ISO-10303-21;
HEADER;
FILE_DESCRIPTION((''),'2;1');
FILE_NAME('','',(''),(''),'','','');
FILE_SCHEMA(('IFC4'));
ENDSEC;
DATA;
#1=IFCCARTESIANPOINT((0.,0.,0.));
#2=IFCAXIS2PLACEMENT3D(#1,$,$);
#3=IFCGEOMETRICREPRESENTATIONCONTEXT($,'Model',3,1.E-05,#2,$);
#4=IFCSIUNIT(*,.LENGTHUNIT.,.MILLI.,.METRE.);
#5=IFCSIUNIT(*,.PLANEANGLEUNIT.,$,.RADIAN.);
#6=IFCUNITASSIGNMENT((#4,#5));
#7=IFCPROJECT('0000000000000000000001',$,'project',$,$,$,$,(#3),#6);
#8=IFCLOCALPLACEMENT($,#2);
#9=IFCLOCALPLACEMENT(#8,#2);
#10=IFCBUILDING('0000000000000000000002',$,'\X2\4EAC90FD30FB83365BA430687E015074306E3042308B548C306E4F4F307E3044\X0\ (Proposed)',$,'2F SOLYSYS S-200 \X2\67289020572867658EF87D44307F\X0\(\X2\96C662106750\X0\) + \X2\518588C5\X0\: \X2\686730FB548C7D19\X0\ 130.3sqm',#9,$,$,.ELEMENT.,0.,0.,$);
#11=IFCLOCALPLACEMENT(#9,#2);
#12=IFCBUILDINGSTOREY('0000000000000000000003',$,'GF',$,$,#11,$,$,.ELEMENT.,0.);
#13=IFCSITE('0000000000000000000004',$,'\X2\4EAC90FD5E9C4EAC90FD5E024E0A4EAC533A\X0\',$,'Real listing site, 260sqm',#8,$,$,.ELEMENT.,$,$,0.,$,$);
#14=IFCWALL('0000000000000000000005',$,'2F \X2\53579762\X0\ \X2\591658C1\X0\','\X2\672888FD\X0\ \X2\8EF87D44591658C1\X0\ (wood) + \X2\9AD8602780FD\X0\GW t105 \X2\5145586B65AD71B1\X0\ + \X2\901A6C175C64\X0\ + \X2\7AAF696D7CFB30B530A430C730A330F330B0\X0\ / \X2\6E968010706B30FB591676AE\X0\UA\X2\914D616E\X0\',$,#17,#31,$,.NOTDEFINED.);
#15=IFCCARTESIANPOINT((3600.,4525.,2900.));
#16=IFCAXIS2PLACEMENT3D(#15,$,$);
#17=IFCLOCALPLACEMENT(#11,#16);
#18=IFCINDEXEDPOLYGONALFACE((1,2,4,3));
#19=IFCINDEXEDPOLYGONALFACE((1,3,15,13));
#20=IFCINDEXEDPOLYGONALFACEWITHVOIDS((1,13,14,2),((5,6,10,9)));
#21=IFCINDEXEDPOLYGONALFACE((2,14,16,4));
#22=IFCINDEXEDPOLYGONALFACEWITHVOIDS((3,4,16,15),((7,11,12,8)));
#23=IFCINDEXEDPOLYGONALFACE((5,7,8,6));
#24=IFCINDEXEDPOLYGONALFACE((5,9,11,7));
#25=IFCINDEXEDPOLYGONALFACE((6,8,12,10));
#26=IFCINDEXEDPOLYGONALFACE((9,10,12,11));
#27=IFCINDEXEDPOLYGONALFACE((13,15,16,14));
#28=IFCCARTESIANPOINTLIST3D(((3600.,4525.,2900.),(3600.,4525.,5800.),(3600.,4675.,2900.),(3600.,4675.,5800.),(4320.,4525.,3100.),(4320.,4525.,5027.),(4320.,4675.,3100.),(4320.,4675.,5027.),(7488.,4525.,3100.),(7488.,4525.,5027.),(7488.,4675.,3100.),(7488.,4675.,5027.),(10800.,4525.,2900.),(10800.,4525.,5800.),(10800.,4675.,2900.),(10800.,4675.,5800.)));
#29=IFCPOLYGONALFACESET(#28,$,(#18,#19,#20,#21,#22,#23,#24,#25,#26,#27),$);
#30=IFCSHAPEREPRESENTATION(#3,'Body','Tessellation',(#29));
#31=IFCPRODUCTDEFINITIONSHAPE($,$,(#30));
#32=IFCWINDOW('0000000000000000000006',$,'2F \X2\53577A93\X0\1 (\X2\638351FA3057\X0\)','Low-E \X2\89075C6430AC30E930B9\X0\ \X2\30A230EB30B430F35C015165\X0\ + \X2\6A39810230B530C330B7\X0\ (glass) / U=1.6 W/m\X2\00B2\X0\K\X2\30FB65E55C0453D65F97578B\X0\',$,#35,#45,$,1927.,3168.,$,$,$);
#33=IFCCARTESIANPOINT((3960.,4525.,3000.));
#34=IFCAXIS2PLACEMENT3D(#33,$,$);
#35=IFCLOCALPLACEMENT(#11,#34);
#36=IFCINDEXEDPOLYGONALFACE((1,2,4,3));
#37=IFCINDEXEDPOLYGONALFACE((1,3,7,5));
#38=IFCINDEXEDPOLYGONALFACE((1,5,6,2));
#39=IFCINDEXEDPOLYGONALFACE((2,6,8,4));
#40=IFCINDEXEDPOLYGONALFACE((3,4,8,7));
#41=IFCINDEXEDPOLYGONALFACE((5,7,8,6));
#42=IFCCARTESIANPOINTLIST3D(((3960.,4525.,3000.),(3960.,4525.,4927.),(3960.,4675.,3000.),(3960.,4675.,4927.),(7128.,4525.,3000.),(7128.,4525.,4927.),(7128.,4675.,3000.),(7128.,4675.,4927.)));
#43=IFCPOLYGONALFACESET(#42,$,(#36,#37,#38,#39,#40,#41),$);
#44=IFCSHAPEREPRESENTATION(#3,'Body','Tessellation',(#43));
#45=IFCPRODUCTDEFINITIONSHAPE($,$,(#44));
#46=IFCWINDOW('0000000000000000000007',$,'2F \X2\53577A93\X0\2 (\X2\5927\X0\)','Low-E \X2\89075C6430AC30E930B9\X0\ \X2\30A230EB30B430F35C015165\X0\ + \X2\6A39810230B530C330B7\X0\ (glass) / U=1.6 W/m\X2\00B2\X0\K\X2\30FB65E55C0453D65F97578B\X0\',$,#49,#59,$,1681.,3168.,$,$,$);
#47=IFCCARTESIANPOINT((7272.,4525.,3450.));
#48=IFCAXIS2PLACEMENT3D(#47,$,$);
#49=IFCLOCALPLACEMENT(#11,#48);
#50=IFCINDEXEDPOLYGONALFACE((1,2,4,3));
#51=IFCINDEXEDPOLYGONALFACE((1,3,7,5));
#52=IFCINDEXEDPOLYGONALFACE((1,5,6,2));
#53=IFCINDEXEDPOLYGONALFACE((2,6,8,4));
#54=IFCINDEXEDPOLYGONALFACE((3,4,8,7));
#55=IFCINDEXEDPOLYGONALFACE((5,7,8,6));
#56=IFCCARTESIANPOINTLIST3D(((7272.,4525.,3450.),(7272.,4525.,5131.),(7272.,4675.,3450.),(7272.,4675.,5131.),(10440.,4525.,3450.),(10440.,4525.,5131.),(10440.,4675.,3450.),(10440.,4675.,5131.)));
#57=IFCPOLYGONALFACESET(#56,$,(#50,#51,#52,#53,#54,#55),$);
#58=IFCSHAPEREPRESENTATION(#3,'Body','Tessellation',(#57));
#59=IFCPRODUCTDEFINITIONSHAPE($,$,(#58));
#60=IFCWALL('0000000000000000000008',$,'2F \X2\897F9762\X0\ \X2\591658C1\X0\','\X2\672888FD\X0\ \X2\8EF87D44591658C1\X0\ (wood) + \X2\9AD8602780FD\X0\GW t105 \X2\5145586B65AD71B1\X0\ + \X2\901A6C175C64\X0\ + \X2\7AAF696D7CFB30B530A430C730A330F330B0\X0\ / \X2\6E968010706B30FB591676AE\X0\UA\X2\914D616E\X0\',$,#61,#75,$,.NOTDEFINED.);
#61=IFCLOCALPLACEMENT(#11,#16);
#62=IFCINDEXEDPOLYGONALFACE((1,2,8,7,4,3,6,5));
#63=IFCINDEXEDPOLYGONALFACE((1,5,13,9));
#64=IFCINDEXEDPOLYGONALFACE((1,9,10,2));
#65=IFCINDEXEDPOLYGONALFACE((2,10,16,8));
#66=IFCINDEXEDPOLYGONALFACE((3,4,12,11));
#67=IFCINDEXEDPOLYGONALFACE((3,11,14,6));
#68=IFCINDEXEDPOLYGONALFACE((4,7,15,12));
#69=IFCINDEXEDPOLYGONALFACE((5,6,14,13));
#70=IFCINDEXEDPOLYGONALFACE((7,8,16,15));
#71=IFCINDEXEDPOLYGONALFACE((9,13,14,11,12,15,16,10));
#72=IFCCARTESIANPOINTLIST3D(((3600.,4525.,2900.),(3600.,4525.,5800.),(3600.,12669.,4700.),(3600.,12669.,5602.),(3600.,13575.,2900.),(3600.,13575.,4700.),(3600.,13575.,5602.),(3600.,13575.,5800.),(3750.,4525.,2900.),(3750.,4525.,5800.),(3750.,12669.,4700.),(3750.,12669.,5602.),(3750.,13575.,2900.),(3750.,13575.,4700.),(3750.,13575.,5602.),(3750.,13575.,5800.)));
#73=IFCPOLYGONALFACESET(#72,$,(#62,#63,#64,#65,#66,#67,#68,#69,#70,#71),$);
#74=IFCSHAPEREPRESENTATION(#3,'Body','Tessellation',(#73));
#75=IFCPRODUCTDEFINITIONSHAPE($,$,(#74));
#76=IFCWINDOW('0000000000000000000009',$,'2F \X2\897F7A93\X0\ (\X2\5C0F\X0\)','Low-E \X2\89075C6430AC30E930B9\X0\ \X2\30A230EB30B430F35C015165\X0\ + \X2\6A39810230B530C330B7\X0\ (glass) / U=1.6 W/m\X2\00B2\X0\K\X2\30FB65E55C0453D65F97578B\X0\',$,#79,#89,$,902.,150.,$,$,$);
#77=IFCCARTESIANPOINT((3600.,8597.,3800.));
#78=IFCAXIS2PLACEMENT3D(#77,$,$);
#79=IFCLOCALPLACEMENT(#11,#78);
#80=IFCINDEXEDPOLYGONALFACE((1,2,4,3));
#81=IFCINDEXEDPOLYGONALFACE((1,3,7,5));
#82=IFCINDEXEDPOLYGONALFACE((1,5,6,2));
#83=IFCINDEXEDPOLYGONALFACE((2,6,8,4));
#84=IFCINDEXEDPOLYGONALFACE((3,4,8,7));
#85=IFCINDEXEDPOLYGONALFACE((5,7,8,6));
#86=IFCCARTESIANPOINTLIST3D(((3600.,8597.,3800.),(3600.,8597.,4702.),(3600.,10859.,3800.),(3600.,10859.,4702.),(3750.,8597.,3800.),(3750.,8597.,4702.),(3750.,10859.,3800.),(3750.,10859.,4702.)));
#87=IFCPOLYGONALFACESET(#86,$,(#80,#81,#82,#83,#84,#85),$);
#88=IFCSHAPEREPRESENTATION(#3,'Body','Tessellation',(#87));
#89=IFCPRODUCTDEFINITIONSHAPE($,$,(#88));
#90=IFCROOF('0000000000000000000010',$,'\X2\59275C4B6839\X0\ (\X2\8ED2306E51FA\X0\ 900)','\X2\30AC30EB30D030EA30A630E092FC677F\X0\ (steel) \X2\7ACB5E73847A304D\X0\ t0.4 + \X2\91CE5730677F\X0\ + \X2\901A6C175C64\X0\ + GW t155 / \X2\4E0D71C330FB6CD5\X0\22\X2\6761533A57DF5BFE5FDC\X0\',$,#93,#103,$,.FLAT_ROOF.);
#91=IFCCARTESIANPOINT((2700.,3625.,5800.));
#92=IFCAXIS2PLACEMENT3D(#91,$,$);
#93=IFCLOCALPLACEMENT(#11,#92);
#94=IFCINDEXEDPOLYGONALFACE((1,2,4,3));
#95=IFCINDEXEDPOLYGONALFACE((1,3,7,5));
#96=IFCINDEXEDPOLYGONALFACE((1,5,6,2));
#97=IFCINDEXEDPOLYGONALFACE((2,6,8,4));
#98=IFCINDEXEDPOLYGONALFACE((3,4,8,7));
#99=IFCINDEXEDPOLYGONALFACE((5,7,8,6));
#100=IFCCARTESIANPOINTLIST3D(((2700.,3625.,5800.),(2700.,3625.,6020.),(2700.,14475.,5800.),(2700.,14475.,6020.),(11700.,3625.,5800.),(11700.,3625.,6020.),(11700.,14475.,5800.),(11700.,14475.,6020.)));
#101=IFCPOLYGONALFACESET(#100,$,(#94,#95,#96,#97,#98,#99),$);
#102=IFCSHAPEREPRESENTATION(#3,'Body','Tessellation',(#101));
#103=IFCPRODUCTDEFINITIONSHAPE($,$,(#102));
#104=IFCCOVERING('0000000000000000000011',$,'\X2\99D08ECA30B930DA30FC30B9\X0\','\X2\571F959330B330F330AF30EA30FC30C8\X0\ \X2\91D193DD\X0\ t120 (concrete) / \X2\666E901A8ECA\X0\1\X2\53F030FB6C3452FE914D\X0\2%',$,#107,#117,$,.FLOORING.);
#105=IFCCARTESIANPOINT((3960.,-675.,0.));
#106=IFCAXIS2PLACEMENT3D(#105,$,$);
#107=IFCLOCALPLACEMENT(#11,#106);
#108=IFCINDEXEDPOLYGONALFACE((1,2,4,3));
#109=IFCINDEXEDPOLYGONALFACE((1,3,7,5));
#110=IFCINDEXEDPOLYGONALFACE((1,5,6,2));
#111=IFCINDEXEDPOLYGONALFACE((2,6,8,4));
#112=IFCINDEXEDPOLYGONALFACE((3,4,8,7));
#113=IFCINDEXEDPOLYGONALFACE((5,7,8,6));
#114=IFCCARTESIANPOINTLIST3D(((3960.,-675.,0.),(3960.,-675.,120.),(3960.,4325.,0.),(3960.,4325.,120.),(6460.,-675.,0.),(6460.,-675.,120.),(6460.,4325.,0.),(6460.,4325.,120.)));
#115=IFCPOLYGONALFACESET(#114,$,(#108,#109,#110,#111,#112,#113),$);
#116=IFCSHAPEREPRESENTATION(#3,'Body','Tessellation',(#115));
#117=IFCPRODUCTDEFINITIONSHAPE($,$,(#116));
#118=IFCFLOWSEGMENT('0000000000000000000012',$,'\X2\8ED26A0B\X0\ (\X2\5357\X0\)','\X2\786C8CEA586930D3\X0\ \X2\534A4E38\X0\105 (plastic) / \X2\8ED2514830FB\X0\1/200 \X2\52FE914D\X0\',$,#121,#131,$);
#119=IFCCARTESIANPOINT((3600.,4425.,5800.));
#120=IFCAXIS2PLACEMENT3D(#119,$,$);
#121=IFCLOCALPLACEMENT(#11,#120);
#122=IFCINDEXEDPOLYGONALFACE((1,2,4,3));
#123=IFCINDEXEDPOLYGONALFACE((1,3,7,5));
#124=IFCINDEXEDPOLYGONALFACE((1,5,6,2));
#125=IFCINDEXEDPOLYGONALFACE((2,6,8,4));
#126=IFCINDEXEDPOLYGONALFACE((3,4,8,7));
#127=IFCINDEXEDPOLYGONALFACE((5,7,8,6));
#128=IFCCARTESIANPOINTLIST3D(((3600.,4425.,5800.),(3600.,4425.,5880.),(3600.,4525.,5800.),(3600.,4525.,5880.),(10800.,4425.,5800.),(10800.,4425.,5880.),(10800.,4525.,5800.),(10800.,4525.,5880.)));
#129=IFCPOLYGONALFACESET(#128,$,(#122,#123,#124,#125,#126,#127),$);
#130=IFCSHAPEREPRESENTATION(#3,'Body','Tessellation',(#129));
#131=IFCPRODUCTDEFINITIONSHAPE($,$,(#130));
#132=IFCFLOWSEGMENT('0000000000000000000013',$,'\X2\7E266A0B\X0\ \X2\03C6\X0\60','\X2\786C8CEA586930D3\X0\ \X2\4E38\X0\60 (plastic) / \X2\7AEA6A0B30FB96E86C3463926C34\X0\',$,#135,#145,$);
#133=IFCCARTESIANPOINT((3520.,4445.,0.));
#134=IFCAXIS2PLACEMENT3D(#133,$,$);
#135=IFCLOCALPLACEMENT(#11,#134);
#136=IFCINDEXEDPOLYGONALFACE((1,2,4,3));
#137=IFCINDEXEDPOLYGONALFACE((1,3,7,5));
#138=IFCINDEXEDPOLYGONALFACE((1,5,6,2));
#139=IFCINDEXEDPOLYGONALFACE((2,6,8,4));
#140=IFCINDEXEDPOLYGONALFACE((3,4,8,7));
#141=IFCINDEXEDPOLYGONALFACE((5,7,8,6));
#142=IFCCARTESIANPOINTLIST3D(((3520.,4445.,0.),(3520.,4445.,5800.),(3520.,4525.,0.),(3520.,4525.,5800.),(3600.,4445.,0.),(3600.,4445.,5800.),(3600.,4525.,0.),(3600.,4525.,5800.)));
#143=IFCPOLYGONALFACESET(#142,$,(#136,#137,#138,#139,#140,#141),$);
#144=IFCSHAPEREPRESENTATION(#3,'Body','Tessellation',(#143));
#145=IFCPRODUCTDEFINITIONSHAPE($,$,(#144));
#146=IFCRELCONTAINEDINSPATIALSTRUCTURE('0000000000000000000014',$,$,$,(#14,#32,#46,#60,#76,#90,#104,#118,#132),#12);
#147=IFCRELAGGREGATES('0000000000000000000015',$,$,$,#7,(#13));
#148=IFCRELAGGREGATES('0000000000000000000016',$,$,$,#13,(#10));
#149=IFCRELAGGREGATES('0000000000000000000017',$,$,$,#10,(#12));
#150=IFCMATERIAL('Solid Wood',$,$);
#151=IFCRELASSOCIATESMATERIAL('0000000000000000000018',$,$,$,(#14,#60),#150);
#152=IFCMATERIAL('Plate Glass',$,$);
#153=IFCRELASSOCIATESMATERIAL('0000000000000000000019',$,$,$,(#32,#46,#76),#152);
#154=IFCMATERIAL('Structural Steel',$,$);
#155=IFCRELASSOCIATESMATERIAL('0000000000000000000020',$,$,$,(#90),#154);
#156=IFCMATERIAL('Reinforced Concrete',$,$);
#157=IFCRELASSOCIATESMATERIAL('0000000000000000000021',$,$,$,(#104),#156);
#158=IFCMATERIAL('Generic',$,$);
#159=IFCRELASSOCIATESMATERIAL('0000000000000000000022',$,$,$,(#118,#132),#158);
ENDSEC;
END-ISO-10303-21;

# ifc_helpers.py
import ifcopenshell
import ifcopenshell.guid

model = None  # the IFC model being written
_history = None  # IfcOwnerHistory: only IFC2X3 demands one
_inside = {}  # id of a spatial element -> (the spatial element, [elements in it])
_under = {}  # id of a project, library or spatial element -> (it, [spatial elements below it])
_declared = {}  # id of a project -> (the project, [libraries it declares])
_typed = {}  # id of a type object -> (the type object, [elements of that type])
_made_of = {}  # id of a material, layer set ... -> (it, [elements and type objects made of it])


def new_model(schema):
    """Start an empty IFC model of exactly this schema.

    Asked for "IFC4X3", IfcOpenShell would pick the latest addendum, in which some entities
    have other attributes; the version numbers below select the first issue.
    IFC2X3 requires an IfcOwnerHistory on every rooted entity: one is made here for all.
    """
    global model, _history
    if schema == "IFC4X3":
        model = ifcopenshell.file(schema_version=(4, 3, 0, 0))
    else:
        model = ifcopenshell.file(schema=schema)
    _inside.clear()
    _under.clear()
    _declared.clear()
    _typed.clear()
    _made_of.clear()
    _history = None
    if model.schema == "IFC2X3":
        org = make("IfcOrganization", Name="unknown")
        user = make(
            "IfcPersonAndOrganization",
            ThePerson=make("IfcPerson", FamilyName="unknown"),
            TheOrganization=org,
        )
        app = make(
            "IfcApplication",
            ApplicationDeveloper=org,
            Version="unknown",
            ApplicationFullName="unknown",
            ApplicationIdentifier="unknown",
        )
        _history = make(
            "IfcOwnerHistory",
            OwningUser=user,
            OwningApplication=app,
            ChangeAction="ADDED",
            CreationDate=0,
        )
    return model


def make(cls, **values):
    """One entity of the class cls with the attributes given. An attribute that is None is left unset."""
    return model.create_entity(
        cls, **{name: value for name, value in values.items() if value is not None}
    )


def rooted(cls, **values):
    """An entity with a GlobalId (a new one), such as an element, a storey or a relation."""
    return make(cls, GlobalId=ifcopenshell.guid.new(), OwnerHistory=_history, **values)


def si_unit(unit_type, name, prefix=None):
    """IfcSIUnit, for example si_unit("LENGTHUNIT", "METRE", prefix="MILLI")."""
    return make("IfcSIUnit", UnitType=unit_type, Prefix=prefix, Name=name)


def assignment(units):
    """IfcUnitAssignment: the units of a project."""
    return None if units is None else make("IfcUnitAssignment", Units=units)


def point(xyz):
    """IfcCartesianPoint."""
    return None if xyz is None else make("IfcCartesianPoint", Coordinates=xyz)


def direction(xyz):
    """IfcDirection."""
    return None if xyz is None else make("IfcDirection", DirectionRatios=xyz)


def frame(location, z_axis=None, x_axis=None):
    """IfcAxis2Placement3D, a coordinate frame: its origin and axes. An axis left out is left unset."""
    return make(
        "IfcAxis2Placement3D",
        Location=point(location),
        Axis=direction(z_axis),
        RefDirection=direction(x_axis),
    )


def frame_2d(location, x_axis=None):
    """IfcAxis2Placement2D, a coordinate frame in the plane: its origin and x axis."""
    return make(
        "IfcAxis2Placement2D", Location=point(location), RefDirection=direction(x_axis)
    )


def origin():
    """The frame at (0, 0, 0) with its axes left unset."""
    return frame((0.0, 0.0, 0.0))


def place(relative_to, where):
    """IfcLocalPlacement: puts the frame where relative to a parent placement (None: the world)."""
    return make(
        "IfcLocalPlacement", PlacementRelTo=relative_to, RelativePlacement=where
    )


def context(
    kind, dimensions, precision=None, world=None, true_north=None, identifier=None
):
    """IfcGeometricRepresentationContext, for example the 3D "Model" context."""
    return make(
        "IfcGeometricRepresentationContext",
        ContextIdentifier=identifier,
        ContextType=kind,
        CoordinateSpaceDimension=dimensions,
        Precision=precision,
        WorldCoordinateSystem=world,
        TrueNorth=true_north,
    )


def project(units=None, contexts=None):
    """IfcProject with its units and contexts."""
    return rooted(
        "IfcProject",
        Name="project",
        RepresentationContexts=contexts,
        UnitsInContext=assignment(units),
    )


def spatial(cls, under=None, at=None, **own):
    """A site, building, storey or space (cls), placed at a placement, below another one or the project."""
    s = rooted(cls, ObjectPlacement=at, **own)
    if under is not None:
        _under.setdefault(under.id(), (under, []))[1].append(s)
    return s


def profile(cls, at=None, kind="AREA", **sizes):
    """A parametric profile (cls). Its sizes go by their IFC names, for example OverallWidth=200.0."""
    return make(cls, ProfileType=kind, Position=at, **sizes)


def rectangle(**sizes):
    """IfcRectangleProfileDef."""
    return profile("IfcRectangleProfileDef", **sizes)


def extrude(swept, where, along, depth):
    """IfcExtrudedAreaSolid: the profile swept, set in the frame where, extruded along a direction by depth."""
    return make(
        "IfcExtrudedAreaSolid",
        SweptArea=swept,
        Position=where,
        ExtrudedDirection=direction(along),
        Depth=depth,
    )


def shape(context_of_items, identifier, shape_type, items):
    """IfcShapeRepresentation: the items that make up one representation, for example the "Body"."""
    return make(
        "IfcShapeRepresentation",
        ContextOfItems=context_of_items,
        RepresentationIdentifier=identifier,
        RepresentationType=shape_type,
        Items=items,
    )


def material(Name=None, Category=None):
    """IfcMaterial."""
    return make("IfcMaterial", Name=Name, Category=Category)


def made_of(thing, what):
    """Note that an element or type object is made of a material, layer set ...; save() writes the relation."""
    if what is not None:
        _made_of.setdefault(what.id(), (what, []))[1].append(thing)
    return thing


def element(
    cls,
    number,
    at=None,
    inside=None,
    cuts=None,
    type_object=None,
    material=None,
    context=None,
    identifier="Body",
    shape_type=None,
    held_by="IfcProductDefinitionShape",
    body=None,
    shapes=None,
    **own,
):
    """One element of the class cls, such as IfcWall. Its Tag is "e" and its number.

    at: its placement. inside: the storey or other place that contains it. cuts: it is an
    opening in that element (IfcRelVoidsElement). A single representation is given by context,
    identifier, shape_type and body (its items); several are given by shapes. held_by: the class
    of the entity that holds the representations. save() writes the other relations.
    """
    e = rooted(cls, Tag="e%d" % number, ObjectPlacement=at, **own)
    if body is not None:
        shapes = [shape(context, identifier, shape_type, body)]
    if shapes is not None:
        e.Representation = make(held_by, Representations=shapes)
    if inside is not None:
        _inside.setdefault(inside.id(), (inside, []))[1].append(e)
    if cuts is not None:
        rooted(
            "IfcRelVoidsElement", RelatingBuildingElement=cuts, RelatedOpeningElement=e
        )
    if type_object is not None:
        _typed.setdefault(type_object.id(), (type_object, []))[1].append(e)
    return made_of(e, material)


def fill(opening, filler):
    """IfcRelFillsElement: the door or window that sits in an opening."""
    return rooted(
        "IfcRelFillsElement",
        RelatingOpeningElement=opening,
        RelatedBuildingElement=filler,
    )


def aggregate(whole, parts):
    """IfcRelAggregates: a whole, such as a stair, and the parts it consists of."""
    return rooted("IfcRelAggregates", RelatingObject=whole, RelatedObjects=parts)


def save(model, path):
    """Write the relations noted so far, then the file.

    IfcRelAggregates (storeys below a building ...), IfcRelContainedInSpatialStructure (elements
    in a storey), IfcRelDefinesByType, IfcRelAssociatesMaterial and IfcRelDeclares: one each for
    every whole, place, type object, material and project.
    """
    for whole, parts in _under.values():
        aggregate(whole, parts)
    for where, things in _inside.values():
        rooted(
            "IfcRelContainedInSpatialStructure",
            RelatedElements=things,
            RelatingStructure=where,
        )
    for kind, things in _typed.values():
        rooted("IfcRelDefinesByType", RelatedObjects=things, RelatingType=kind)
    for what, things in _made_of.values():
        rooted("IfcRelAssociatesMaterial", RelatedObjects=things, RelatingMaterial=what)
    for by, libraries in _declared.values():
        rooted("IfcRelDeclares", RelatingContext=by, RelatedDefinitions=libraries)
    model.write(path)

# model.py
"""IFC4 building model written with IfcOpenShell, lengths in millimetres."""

from ifc_helpers import new_model, si_unit, frame, frame_2d, origin, place, context, project, spatial, rectangle, extrude, material, element, fill, save


model = new_model("IFC4")

# Units and contexts
model_context = context("Model", 3, precision=1e-05, world=origin())
ifc_project = project(units=[si_unit("LENGTHUNIT", "METRE", prefix="MILLI"), si_unit("PLANEANGLEUNIT", "RADIAN")], contexts=[model_context])

# Site, building, storey
site_placement = place(None, origin())
site = spatial("IfcSite", under=ifc_project, at=site_placement, Name="京都府京都市上京区", ObjectType="Real listing site, 260sqm", CompositionType="ELEMENT", RefElevation=0.0)
building_placement = place(site_placement, origin())
building = spatial("IfcBuilding", under=site, at=building_placement, Name="京都・茶室と縁側のある和の住まい (Proposed)", ObjectType="2F SOLYSYS S-200 木造在来軸組み(集成材) + 内装: 桧・和紙 130.3sqm", CompositionType="ELEMENT", ElevationOfRefHeight=0.0, ElevationOfTerrain=0.0)
storey_placement = place(building_placement, origin())
storey = spatial("IfcBuildingStorey", under=building, at=storey_placement, Name="GF", CompositionType="ELEMENT", Elevation=0.0)

# Shared definitions
ifc_material_1 = material(Name="Solid Wood")

# Shared definitions
ifc_material_2 = material(Name="Reinforced Concrete")

# Shared definitions
ifc_material_3 = material(Name="Plate Glass")

# Wall, openings, windows
wall_1_placement = place(storey_placement, frame((3600.0, 4525.0, 2900.0)))
wall_1 = element("IfcWall", 1, at=wall_1_placement, inside=storey, material=ifc_material_1, Name="2F 南面 外壁", Description="木製 軸組外壁 (wood) + 高性能GW t105 充填断熱 + 通気層 + 窯業系サイディング / 準耐火・外皮UA配慮", PredefinedType="NOTDEFINED", context=model_context, shape_type="SweptSolid", body=[
    extrude(rectangle(XDim=7200.0, YDim=150.0, at=frame_2d((3600.0, 75.0))), frame((3600.0, 4525.0, 2900.0)), (0.0, 0.0, 1.0), 2900.0),
])
opening_1_placement = place(storey_placement, frame((3960.0, 4525.0, 3000.0)))
opening_1 = element("IfcOpeningElement", 2, at=opening_1_placement, cuts=wall_1, PredefinedType="NOTDEFINED", context=model_context, shape_type="SweptSolid", body=[
    extrude(rectangle(XDim=3168.0, YDim=150.0, at=frame_2d((1584.0, 75.0))), frame((3960.0, 4525.0, 3000.0)), (0.0, 0.0, 1.0), 1927.0),
])
opening_2_placement = place(storey_placement, frame((7272.0, 4525.0, 3450.0)))
opening_2 = element("IfcOpeningElement", 3, at=opening_2_placement, cuts=wall_1, PredefinedType="NOTDEFINED", context=model_context, shape_type="SweptSolid", body=[
    extrude(rectangle(XDim=3168.0, YDim=150.0, at=frame_2d((1584.0, 75.0))), frame((7272.0, 4525.0, 3450.0)), (0.0, 0.0, 1.0), 1681.0),
])
window_1_placement = place(storey_placement, frame((3960.0, 4525.0, 3000.0)))
window_1 = element("IfcWindow", 4, at=window_1_placement, inside=storey, material=ifc_material_3, Name="2F 南窓1 (掃出し)", Description="Low-E 複層ガラス アルゴン封入 + 樹脂サッシ (glass) / U=1.6 W/m²K・日射取得型", OverallHeight=1927.0, OverallWidth=3168.0, context=model_context, shape_type="SweptSolid", body=[
    extrude(rectangle(XDim=3168.0, YDim=150.0, at=frame_2d((1584.0, 75.0))), frame((3960.0, 4525.0, 3000.0)), (0.0, 0.0, 1.0), 1927.0),
])
fill(opening_1, window_1)
window_2_placement = place(storey_placement, frame((7272.0, 4525.0, 3450.0)))
window_2 = element("IfcWindow", 5, at=window_2_placement, inside=storey, material=ifc_material_3, Name="2F 南窓2 (大)", Description="Low-E 複層ガラス アルゴン封入 + 樹脂サッシ (glass) / U=1.6 W/m²K・日射取得型", OverallHeight=1681.0, OverallWidth=3168.0, context=model_context, shape_type="SweptSolid", body=[
    extrude(rectangle(XDim=3168.0, YDim=150.0, at=frame_2d((1584.0, 75.0))), frame((7272.0, 4525.0, 3450.0)), (0.0, 0.0, 1.0), 1681.0),
])
fill(opening_2, window_2)

# Wall, opening, window
wall_2_placement = place(storey_placement, frame((3600.0, 4525.0, 2900.0)))
wall_2 = element("IfcWall", 6, at=wall_2_placement, inside=storey, material=ifc_material_1, Name="2F 西面 外壁", Description="木製 軸組外壁 (wood) + 高性能GW t105 充填断熱 + 通気層 + 窯業系サイディング / 準耐火・外皮UA配慮", PredefinedType="NOTDEFINED", context=model_context, shape_type="SweptSolid", body=[
    extrude(rectangle(XDim=150.0, YDim=9050.0, at=frame_2d((75.0, 4525.0))), frame((3600.0, 4525.0, 2900.0)), (0.0, 0.0, 1.0), 2900.0),
])
opening_3_placement = place(storey_placement, frame((3600.0, 8597.0, 3800.0)))
opening_3 = element("IfcOpeningElement", 7, at=opening_3_placement, cuts=wall_2, PredefinedType="NOTDEFINED", context=model_context, shape_type="SweptSolid", body=[
    extrude(rectangle(XDim=150.0, YDim=2262.0, at=frame_2d((75.0, 1131.0))), frame((3600.0, 8597.0, 3800.0)), (0.0, 0.0, 1.0), 902.0),
])
window_3_placement = place(storey_placement, frame((3600.0, 8597.0, 3800.0)))
window_3 = element("IfcWindow", 8, at=window_3_placement, inside=storey, material=ifc_material_3, Name="2F 西窓 (小)", Description="Low-E 複層ガラス アルゴン封入 + 樹脂サッシ (glass) / U=1.6 W/m²K・日射取得型", OverallHeight=902.0, OverallWidth=150.0, context=model_context, shape_type="SweptSolid", body=[
    extrude(rectangle(XDim=150.0, YDim=2262.0, at=frame_2d((75.0, 1131.0))), frame((3600.0, 8597.0, 3800.0)), (0.0, 0.0, 1.0), 902.0),
])
fill(opening_3, window_3)

# Roof
ifc_material_4 = material(Name="Structural Steel")
roof_placement = place(storey_placement, frame((2700.0, 3625.0, 5800.0)))
element("IfcRoof", 9, at=roof_placement, inside=storey, material=ifc_material_4, Name="大屋根 (軒の出 900)", Description="ガルバリウム鋼板 (steel) 立平葺き t0.4 + 野地板 + 通気層 + GW t155 / 不燃・法22条区域対応", PredefinedType="FLAT_ROOF", context=model_context, shape_type="SweptSolid", body=[
    extrude(rectangle(XDim=9000.0, YDim=10850.0, at=frame_2d((4500.0, 5425.0))), frame((2700.0, 3625.0, 5800.0)), (0.0, 0.0, 1.0), 220.0),
])

# Covering
covering_placement = place(storey_placement, frame((3960.0, -675.0, 0.0)))
element("IfcCovering", 10, at=covering_placement, inside=storey, material=ifc_material_2, Name="駐車スペース", Description="土間コンクリート 金鏝 t120 (concrete) / 普通車1台・水勾配2%", PredefinedType="FLOORING", context=model_context, shape_type="SweptSolid", body=[
    extrude(rectangle(XDim=2500.0, YDim=5000.0, at=frame_2d((1250.0, 2500.0))), frame((3960.0, -675.0, 0.0)), (0.0, 0.0, 1.0), 120.0),
])

# Flow segments
ifc_material_5 = material(Name="Generic")
flow_segment_1_placement = place(storey_placement, frame((3600.0, 4425.0, 5800.0)))
element("IfcFlowSegment", 11, at=flow_segment_1_placement, inside=storey, material=ifc_material_5, Name="軒樋 (南)", Description="硬質塩ビ 半丸105 (plastic) / 軒先・1/200 勾配", context=model_context, shape_type="SweptSolid", body=[
    extrude(rectangle(XDim=7200.0, YDim=100.0, at=frame_2d((3600.0, 50.0))), frame((3600.0, 4425.0, 5800.0)), (0.0, 0.0, 1.0), 80.0),
])
flow_segment_2_placement = place(storey_placement, frame((3520.0, 4445.0, 0.0)))
element("IfcFlowSegment", 12, at=flow_segment_2_placement, inside=storey, material=ifc_material_5, Name="縦樋 φ60", Description="硬質塩ビ 丸60 (plastic) / 竪樋・雨水排水", context=model_context, shape_type="SweptSolid", body=[
    extrude(rectangle(XDim=80.0, YDim=80.0, at=frame_2d((40.0, 40.0))), frame((3520.0, 4445.0, 0.0)), (0.0, 0.0, 1.0), 5800.0),
])

save(model, "model.ifc")
